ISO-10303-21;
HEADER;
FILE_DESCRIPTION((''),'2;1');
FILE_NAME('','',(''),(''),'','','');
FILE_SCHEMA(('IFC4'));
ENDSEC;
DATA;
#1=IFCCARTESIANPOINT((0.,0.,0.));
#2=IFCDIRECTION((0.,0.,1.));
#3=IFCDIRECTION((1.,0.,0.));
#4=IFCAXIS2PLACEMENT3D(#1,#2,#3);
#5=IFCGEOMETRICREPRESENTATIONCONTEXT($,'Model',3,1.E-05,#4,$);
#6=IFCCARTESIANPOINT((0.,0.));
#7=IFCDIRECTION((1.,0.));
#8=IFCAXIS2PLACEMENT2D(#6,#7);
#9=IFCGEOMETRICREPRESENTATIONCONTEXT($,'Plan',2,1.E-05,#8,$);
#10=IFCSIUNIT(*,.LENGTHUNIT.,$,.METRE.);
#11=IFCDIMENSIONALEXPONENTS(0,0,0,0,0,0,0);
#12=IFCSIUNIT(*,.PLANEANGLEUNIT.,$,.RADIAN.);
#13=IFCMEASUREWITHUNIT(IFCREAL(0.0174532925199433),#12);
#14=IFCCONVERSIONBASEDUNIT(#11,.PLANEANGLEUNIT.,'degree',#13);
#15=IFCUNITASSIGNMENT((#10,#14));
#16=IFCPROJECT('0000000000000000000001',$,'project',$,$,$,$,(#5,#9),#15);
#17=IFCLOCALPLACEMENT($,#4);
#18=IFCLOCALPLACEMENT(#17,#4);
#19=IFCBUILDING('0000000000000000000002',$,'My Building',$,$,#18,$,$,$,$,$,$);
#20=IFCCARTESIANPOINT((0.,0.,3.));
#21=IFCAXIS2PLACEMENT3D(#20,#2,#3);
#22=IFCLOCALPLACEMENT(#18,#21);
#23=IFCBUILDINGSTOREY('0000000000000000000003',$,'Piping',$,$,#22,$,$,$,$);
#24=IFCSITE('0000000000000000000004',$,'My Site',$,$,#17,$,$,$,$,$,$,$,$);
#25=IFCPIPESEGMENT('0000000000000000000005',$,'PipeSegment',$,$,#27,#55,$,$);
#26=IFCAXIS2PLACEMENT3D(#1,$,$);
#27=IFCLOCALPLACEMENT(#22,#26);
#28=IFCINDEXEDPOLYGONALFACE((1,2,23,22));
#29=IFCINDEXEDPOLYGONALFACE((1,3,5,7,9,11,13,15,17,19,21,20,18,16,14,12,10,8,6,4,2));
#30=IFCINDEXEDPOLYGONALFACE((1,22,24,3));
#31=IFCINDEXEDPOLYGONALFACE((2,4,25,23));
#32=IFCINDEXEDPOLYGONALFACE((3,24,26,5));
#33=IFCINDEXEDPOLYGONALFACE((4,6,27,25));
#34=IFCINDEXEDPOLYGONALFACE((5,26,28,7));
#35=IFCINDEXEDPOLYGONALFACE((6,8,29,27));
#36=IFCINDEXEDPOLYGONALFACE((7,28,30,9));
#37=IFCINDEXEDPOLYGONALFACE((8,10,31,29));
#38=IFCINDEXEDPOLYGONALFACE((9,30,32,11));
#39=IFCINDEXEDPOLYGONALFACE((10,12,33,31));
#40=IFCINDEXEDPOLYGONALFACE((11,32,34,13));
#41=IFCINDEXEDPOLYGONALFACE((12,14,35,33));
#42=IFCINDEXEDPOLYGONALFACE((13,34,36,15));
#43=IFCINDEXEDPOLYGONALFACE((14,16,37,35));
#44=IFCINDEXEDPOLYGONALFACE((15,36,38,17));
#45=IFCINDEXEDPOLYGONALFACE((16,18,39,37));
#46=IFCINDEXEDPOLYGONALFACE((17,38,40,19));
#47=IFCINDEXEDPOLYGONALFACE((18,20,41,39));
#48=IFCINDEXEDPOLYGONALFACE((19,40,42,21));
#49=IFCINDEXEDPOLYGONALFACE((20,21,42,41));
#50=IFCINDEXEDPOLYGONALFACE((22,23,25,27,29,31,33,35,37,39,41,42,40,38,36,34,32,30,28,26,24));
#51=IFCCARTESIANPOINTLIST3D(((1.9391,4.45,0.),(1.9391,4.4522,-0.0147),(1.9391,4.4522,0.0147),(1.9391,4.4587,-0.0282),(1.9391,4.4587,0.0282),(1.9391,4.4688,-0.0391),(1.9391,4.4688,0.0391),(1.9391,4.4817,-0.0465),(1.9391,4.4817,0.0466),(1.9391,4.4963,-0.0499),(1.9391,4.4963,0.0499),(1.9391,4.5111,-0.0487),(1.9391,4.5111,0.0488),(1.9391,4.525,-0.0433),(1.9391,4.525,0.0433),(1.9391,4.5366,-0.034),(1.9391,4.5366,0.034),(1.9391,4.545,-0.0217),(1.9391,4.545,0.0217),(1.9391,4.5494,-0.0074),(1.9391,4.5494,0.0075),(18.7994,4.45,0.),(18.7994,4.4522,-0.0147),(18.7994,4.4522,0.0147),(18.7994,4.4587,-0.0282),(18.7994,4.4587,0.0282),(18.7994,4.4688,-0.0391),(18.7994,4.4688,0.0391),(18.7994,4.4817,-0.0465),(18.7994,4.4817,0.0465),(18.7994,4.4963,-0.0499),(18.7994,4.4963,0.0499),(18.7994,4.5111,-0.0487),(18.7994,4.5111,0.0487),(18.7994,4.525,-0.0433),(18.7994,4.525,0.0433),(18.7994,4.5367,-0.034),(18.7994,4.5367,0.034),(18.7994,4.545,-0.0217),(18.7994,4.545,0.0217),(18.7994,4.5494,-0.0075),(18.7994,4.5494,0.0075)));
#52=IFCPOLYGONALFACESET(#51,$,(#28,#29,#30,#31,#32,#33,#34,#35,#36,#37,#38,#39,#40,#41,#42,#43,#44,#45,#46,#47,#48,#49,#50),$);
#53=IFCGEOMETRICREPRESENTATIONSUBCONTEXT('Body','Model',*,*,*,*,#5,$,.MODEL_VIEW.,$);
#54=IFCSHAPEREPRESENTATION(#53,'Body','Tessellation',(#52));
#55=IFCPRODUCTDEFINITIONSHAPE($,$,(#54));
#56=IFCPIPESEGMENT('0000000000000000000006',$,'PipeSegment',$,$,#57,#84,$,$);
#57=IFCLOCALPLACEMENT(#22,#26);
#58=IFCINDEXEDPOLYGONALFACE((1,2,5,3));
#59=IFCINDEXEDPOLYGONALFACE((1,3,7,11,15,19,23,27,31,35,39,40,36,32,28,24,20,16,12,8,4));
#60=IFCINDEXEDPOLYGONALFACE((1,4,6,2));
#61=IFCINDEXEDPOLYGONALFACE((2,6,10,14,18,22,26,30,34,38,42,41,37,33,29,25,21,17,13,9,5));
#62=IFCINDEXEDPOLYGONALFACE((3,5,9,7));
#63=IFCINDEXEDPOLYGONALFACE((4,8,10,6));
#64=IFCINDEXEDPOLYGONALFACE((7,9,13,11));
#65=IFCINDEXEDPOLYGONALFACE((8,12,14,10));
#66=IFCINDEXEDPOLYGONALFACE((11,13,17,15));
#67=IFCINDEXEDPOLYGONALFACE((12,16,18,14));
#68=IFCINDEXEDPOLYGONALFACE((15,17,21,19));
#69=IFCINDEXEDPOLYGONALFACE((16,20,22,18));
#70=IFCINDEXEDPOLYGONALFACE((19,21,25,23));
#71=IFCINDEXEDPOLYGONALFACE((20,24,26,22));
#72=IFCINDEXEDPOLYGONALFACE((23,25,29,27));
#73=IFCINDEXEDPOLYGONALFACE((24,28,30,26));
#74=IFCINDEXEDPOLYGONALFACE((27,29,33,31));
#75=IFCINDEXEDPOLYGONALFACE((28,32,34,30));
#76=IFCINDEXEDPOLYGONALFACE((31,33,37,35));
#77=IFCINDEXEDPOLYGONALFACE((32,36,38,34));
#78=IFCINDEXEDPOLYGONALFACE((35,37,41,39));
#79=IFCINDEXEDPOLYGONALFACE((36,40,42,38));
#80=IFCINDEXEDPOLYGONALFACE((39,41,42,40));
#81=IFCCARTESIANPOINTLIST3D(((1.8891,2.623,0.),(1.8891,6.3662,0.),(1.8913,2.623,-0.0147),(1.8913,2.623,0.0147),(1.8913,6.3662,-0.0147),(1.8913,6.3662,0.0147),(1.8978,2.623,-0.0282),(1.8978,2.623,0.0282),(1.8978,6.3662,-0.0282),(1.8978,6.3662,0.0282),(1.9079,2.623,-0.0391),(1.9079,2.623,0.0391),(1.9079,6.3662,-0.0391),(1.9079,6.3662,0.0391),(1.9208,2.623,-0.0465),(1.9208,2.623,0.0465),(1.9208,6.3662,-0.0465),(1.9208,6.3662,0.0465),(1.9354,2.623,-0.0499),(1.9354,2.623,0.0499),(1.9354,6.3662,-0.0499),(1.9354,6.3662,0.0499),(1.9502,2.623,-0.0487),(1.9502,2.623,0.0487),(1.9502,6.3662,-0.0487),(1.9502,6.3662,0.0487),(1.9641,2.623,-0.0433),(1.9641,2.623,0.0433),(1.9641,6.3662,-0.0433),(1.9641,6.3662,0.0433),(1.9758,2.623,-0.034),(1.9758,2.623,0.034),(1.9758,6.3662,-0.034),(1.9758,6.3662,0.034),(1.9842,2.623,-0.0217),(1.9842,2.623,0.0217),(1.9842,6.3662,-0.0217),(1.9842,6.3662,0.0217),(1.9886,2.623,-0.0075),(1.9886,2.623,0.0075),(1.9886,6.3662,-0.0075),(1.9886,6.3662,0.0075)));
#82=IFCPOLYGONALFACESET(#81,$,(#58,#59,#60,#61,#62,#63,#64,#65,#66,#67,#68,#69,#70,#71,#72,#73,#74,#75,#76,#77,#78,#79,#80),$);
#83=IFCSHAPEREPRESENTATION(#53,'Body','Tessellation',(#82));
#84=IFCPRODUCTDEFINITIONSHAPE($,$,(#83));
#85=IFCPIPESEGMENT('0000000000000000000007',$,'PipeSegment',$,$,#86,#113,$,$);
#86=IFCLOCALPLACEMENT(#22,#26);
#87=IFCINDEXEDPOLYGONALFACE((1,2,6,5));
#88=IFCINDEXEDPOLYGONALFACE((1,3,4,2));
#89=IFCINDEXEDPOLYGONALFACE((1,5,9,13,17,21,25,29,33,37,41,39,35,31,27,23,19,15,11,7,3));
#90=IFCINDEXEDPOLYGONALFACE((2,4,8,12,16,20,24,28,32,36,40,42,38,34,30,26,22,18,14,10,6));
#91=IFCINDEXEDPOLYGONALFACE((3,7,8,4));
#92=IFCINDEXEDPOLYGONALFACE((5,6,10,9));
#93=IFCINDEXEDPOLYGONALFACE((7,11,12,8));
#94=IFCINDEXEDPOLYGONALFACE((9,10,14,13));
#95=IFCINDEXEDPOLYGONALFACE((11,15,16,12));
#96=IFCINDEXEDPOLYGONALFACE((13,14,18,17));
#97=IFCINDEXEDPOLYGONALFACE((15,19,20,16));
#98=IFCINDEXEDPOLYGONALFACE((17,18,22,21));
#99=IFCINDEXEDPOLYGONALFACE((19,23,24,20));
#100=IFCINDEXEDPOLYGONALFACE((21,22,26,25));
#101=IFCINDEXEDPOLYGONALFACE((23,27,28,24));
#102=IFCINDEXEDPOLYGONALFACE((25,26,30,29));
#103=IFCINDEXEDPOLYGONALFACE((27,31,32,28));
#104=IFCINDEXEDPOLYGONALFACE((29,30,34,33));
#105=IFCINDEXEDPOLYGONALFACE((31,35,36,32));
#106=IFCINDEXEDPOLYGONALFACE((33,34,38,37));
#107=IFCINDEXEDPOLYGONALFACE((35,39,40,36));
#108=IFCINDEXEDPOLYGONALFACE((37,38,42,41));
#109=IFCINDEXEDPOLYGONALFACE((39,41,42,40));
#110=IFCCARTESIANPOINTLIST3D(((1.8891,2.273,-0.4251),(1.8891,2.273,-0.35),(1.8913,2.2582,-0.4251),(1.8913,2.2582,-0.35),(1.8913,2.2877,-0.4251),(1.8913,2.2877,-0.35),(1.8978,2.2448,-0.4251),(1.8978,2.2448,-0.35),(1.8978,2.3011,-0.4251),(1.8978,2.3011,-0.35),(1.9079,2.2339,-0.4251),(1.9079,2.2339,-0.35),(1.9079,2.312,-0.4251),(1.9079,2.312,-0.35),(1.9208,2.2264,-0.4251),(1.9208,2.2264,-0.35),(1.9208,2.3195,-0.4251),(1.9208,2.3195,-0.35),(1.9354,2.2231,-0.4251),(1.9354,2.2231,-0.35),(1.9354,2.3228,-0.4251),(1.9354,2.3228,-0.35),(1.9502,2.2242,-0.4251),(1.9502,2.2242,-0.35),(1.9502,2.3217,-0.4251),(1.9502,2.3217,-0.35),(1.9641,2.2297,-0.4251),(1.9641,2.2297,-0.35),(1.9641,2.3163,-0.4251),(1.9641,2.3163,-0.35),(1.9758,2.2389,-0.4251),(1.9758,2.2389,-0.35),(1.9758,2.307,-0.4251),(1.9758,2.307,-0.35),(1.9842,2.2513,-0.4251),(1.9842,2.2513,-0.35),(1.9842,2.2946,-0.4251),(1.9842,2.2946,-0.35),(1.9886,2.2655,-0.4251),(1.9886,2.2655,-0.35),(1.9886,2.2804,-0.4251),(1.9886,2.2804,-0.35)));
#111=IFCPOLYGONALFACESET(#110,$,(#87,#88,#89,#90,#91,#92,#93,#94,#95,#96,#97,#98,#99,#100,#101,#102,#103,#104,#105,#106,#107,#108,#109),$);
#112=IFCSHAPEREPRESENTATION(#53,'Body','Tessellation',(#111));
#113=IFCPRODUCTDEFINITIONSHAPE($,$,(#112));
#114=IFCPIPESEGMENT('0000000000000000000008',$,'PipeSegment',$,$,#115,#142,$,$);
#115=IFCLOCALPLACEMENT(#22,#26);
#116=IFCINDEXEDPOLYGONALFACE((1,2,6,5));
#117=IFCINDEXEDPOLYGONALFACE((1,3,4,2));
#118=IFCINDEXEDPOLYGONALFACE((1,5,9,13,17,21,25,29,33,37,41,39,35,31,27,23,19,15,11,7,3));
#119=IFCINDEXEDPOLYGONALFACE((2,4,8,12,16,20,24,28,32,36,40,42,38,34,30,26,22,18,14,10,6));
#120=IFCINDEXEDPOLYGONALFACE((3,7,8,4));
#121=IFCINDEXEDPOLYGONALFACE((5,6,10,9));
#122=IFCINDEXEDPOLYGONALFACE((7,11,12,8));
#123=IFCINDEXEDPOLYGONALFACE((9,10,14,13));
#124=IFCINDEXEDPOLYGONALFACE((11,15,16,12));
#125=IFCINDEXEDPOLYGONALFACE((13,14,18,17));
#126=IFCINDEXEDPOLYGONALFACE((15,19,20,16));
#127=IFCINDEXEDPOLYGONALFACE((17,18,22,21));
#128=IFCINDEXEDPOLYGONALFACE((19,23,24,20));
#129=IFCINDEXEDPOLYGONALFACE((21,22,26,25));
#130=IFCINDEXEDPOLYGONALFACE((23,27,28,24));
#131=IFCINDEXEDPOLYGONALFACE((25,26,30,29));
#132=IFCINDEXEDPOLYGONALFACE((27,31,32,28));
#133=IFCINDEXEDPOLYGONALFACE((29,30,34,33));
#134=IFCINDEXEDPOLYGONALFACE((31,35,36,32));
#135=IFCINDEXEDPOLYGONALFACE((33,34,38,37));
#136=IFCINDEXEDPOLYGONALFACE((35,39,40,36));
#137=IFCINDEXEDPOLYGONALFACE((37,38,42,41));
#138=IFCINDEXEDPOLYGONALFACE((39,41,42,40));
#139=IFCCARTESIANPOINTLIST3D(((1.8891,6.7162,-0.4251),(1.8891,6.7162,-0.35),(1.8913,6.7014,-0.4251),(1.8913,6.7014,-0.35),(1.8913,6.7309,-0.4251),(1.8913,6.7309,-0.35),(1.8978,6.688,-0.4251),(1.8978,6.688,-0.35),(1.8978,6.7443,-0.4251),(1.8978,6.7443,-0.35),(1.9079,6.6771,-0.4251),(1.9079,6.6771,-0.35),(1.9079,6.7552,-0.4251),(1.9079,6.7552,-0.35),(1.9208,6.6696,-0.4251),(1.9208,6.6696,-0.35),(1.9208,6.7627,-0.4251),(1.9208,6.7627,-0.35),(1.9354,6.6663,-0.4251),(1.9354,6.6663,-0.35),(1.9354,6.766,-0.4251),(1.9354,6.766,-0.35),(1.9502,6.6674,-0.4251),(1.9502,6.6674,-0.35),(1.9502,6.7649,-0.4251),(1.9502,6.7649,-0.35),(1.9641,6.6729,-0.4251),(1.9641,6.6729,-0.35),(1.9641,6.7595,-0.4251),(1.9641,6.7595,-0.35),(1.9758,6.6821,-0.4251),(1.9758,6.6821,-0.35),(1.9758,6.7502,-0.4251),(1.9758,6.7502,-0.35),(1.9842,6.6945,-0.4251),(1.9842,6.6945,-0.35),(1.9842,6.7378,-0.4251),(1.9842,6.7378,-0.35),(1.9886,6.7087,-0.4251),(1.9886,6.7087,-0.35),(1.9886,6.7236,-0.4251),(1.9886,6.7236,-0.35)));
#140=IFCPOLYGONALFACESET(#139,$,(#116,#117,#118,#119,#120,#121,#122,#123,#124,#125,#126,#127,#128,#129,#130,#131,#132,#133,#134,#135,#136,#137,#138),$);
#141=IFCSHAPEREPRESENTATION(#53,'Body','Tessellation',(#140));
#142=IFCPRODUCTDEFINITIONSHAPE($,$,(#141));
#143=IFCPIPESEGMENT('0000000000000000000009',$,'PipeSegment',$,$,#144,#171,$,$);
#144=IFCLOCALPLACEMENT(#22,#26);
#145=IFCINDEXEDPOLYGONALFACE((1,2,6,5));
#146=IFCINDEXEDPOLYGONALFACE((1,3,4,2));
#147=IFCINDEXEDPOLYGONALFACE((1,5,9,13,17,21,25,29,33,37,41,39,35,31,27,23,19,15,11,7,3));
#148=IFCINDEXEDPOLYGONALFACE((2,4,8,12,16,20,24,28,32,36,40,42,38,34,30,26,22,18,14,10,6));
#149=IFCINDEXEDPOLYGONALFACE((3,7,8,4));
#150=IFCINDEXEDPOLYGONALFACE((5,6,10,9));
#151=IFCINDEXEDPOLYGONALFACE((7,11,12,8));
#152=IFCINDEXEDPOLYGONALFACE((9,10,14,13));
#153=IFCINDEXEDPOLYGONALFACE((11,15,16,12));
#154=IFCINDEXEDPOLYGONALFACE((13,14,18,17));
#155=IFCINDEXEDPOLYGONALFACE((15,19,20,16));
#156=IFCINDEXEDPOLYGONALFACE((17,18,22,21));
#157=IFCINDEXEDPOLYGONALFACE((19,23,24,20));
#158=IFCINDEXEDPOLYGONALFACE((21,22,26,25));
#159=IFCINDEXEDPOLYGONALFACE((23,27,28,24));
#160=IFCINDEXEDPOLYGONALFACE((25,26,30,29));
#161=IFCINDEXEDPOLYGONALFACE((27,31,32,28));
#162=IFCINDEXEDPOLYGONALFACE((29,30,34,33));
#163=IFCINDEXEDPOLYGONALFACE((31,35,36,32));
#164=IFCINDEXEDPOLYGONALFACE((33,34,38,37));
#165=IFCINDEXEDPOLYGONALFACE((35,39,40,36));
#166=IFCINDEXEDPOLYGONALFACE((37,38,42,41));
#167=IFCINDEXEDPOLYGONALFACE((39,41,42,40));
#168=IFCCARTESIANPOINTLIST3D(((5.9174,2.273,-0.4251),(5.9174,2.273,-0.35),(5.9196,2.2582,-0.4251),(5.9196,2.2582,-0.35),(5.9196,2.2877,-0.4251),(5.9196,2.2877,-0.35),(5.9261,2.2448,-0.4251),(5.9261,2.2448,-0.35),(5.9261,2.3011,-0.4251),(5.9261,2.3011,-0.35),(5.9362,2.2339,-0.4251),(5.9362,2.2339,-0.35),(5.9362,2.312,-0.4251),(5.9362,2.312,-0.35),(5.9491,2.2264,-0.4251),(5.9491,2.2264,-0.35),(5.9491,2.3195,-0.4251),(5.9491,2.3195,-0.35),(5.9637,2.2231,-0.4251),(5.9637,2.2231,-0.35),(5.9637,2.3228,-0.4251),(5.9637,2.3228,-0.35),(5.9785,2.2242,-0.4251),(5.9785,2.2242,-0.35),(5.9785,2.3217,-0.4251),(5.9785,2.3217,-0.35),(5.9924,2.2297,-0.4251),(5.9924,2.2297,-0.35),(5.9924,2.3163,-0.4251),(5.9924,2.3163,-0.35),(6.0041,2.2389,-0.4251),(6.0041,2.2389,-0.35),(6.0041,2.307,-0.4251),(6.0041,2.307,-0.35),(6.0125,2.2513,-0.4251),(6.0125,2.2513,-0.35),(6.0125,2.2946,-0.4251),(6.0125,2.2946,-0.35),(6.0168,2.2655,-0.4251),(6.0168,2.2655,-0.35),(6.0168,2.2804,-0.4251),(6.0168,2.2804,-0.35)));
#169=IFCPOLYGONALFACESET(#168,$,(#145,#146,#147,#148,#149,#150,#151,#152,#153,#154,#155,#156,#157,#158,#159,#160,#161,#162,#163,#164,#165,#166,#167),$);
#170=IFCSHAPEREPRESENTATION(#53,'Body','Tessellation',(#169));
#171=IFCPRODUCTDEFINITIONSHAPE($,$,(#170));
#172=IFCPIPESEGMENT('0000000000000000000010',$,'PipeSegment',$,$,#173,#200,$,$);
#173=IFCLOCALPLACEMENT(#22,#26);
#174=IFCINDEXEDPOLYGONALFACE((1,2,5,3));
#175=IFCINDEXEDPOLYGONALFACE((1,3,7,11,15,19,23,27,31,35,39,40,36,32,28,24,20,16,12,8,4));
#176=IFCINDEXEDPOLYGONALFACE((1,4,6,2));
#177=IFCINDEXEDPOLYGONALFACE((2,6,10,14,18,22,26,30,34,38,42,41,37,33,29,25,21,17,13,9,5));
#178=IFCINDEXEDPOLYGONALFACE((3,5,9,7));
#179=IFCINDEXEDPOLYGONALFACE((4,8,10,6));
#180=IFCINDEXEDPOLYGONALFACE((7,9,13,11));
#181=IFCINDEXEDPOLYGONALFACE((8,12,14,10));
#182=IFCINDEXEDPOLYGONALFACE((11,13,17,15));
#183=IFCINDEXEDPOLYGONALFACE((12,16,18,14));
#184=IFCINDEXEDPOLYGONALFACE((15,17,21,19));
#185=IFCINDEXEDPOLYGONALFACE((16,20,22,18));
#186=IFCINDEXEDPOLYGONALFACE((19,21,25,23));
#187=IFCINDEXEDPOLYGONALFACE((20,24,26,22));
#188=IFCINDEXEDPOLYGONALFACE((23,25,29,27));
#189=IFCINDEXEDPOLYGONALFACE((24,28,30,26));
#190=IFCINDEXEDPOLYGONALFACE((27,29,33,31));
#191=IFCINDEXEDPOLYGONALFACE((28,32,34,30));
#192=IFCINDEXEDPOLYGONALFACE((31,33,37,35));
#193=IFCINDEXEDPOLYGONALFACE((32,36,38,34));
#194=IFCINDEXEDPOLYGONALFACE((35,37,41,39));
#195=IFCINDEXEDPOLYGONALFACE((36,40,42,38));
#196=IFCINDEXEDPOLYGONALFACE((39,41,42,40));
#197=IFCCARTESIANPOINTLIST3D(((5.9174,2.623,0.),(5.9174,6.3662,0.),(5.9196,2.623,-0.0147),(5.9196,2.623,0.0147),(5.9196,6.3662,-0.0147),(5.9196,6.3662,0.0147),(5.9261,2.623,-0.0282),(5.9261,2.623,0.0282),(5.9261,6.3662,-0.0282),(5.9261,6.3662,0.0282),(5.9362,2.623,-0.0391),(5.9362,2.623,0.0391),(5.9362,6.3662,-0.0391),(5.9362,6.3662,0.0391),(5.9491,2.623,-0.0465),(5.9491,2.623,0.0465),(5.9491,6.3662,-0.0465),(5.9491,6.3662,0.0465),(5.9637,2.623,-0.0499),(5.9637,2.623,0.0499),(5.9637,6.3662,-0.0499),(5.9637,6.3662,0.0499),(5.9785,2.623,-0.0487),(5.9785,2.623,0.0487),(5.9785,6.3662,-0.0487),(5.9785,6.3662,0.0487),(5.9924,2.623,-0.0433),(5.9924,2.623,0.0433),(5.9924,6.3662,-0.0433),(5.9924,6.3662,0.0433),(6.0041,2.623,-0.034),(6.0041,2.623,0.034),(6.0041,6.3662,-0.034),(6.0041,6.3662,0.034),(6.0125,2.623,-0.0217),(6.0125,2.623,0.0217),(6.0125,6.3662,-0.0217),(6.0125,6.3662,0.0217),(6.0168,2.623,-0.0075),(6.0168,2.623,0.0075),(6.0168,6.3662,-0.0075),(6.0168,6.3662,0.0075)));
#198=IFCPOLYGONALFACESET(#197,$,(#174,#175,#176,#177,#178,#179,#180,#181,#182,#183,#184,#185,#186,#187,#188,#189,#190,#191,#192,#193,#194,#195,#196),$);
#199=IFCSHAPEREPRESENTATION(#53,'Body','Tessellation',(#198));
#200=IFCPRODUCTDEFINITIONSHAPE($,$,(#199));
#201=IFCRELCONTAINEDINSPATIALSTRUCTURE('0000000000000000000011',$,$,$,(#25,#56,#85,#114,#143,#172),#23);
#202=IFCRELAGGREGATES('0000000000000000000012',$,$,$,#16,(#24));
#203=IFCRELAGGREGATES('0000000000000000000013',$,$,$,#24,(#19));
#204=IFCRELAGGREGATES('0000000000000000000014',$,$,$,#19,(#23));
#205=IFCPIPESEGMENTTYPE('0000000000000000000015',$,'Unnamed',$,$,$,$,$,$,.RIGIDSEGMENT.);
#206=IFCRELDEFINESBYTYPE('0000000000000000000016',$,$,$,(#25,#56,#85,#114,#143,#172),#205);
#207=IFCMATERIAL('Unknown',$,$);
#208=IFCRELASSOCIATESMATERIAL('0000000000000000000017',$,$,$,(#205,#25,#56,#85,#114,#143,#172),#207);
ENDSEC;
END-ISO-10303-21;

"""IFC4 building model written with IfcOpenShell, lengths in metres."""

from ifc_helpers import new_model, entity, si_unit, converted_unit, frame, origin_with_axes, origin_2d_with_axis, place, context, subcontext, project, spatial, circle, extrude, material, material_profile, profile_set, profile_usage, type_object, element, save


model = new_model("IFC4")

# Units and contexts
model_context = context("Model", 3, precision=1e-05, world=origin_with_axes())
plan_context = context("Plan", 2, precision=1e-05, world=origin_2d_with_axis())
body_context = subcontext(model_context, "Body", "Model", "MODEL_VIEW")
ifc_project = project(units=[si_unit("LENGTHUNIT", "METRE"), converted_unit("PLANEANGLEUNIT", "degree", entity("IfcReal", 0.0174532925199433), si_unit("PLANEANGLEUNIT", "RADIAN"), dimensions=[0, 0, 0, 0, 0, 0, 0])], contexts=[model_context, plan_context])

# Site, building, storey
site_placement = place(None, origin_with_axes())
site = spatial("IfcSite", under=ifc_project, at=site_placement, Name="My Site")
building_placement = place(site_placement, origin_with_axes())
building = spatial("IfcBuilding", under=site, at=building_placement, Name="My Building")
storey_placement = place(building_placement, frame((0.0, 0.0, 3.0), z_axis=(0.0, 0.0, 1.0), x_axis=(1.0, 0.0, 0.0)))
storey = spatial("IfcBuildingStorey", under=building, at=storey_placement, Name="Piping")

# Pipe segments
ifc_material = material(Name="Unknown")
ifc_material_profile = material_profile(ifc_material, circle(Radius=0.05))
ifc_profile_set = profile_set([ifc_material_profile])
ifc_profile_usage_1 = profile_usage(ifc_profile_set, cardinal=5)
pipe_segment_type = type_object("IfcPipeSegmentType", Name="Unnamed", PredefinedType="RIGIDSEGMENT", material=ifc_profile_set)
pipe_segment_1_placement = place(storey_placement, frame((18.7994, 4.5, 0.0), z_axis=(-1.0, -0.000001, 0.0), x_axis=(0.000001, -1.0, 0.0)))
element("IfcPipeSegment", 1, at=pipe_segment_1_placement, inside=storey, type_object=pipe_segment_type, material=ifc_profile_usage_1, Name="PipeSegment", context=body_context, shape_type="SweptSolid", body=[
    extrude(circle(Radius=0.05), origin_with_axes(), (0.0, 0.0, 1.0), 16.8603),
])
ifc_profile_usage_2 = profile_usage(ifc_profile_set, cardinal=5)
pipe_segment_2_placement = place(storey_placement, frame((1.9391, 2.623, 0.0), z_axis=(0.0, 1.0, 0.0), x_axis=(-1.0, 0.0, 0.0)))
element("IfcPipeSegment", 2, at=pipe_segment_2_placement, inside=storey, type_object=pipe_segment_type, material=ifc_profile_usage_2, Name="PipeSegment", context=body_context, shape_type="SweptSolid", body=[
    extrude(circle(Radius=0.05), origin_with_axes(), (0.0, 0.0, 1.0), 3.7432),
])
ifc_profile_usage_3 = profile_usage(ifc_profile_set, cardinal=5)
pipe_segment_3_placement = place(storey_placement, frame((1.9391, 2.273, -0.35), z_axis=(0.0, 0.0, -1.0), x_axis=(-1.0, 0.0, 0.0)))
element("IfcPipeSegment", 3, at=pipe_segment_3_placement, inside=storey, type_object=pipe_segment_type, material=ifc_profile_usage_3, Name="PipeSegment", context=body_context, shape_type="SweptSolid", body=[
    extrude(circle(Radius=0.05), origin_with_axes(), (0.0, 0.0, 1.0), 0.0751),
])
ifc_profile_usage_4 = profile_usage(ifc_profile_set, cardinal=5)
pipe_segment_4_placement = place(storey_placement, frame((1.9391, 6.7162, -0.35), z_axis=(0.0, 0.0, -1.0), x_axis=(-1.0, 0.0, 0.0)))
element("IfcPipeSegment", 4, at=pipe_segment_4_placement, inside=storey, type_object=pipe_segment_type, material=ifc_profile_usage_4, Name="PipeSegment", context=body_context, shape_type="SweptSolid", body=[
    extrude(circle(Radius=0.05), origin_with_axes(), (0.0, 0.0, 1.0), 0.0751),
])
ifc_profile_usage_5 = profile_usage(ifc_profile_set, cardinal=5)
pipe_segment_5_placement = place(storey_placement, frame((5.9674, 2.273, -0.35), z_axis=(0.0, 0.0, -1.0), x_axis=(-1.0, 0.0, 0.0)))
element("IfcPipeSegment", 5, at=pipe_segment_5_placement, inside=storey, type_object=pipe_segment_type, material=ifc_profile_usage_5, Name="PipeSegment", context=body_context, shape_type="SweptSolid", body=[
    extrude(circle(Radius=0.05), origin_with_axes(), (0.0, 0.0, 1.0), 0.0751),
])
ifc_profile_usage_6 = profile_usage(ifc_profile_set, cardinal=5)
pipe_segment_6_placement = place(storey_placement, frame((5.9674, 2.623, 0.0), z_axis=(0.0, 1.0, 0.0), x_axis=(-1.0, 0.0, 0.0)))
element("IfcPipeSegment", 6, at=pipe_segment_6_placement, inside=storey, type_object=pipe_segment_type, material=ifc_profile_usage_6, Name="PipeSegment", context=body_context, shape_type="SweptSolid", body=[
    extrude(circle(Radius=0.05), origin_with_axes(), (0.0, 0.0, 1.0), 3.7432),
])

save(model, "model.ifc")
